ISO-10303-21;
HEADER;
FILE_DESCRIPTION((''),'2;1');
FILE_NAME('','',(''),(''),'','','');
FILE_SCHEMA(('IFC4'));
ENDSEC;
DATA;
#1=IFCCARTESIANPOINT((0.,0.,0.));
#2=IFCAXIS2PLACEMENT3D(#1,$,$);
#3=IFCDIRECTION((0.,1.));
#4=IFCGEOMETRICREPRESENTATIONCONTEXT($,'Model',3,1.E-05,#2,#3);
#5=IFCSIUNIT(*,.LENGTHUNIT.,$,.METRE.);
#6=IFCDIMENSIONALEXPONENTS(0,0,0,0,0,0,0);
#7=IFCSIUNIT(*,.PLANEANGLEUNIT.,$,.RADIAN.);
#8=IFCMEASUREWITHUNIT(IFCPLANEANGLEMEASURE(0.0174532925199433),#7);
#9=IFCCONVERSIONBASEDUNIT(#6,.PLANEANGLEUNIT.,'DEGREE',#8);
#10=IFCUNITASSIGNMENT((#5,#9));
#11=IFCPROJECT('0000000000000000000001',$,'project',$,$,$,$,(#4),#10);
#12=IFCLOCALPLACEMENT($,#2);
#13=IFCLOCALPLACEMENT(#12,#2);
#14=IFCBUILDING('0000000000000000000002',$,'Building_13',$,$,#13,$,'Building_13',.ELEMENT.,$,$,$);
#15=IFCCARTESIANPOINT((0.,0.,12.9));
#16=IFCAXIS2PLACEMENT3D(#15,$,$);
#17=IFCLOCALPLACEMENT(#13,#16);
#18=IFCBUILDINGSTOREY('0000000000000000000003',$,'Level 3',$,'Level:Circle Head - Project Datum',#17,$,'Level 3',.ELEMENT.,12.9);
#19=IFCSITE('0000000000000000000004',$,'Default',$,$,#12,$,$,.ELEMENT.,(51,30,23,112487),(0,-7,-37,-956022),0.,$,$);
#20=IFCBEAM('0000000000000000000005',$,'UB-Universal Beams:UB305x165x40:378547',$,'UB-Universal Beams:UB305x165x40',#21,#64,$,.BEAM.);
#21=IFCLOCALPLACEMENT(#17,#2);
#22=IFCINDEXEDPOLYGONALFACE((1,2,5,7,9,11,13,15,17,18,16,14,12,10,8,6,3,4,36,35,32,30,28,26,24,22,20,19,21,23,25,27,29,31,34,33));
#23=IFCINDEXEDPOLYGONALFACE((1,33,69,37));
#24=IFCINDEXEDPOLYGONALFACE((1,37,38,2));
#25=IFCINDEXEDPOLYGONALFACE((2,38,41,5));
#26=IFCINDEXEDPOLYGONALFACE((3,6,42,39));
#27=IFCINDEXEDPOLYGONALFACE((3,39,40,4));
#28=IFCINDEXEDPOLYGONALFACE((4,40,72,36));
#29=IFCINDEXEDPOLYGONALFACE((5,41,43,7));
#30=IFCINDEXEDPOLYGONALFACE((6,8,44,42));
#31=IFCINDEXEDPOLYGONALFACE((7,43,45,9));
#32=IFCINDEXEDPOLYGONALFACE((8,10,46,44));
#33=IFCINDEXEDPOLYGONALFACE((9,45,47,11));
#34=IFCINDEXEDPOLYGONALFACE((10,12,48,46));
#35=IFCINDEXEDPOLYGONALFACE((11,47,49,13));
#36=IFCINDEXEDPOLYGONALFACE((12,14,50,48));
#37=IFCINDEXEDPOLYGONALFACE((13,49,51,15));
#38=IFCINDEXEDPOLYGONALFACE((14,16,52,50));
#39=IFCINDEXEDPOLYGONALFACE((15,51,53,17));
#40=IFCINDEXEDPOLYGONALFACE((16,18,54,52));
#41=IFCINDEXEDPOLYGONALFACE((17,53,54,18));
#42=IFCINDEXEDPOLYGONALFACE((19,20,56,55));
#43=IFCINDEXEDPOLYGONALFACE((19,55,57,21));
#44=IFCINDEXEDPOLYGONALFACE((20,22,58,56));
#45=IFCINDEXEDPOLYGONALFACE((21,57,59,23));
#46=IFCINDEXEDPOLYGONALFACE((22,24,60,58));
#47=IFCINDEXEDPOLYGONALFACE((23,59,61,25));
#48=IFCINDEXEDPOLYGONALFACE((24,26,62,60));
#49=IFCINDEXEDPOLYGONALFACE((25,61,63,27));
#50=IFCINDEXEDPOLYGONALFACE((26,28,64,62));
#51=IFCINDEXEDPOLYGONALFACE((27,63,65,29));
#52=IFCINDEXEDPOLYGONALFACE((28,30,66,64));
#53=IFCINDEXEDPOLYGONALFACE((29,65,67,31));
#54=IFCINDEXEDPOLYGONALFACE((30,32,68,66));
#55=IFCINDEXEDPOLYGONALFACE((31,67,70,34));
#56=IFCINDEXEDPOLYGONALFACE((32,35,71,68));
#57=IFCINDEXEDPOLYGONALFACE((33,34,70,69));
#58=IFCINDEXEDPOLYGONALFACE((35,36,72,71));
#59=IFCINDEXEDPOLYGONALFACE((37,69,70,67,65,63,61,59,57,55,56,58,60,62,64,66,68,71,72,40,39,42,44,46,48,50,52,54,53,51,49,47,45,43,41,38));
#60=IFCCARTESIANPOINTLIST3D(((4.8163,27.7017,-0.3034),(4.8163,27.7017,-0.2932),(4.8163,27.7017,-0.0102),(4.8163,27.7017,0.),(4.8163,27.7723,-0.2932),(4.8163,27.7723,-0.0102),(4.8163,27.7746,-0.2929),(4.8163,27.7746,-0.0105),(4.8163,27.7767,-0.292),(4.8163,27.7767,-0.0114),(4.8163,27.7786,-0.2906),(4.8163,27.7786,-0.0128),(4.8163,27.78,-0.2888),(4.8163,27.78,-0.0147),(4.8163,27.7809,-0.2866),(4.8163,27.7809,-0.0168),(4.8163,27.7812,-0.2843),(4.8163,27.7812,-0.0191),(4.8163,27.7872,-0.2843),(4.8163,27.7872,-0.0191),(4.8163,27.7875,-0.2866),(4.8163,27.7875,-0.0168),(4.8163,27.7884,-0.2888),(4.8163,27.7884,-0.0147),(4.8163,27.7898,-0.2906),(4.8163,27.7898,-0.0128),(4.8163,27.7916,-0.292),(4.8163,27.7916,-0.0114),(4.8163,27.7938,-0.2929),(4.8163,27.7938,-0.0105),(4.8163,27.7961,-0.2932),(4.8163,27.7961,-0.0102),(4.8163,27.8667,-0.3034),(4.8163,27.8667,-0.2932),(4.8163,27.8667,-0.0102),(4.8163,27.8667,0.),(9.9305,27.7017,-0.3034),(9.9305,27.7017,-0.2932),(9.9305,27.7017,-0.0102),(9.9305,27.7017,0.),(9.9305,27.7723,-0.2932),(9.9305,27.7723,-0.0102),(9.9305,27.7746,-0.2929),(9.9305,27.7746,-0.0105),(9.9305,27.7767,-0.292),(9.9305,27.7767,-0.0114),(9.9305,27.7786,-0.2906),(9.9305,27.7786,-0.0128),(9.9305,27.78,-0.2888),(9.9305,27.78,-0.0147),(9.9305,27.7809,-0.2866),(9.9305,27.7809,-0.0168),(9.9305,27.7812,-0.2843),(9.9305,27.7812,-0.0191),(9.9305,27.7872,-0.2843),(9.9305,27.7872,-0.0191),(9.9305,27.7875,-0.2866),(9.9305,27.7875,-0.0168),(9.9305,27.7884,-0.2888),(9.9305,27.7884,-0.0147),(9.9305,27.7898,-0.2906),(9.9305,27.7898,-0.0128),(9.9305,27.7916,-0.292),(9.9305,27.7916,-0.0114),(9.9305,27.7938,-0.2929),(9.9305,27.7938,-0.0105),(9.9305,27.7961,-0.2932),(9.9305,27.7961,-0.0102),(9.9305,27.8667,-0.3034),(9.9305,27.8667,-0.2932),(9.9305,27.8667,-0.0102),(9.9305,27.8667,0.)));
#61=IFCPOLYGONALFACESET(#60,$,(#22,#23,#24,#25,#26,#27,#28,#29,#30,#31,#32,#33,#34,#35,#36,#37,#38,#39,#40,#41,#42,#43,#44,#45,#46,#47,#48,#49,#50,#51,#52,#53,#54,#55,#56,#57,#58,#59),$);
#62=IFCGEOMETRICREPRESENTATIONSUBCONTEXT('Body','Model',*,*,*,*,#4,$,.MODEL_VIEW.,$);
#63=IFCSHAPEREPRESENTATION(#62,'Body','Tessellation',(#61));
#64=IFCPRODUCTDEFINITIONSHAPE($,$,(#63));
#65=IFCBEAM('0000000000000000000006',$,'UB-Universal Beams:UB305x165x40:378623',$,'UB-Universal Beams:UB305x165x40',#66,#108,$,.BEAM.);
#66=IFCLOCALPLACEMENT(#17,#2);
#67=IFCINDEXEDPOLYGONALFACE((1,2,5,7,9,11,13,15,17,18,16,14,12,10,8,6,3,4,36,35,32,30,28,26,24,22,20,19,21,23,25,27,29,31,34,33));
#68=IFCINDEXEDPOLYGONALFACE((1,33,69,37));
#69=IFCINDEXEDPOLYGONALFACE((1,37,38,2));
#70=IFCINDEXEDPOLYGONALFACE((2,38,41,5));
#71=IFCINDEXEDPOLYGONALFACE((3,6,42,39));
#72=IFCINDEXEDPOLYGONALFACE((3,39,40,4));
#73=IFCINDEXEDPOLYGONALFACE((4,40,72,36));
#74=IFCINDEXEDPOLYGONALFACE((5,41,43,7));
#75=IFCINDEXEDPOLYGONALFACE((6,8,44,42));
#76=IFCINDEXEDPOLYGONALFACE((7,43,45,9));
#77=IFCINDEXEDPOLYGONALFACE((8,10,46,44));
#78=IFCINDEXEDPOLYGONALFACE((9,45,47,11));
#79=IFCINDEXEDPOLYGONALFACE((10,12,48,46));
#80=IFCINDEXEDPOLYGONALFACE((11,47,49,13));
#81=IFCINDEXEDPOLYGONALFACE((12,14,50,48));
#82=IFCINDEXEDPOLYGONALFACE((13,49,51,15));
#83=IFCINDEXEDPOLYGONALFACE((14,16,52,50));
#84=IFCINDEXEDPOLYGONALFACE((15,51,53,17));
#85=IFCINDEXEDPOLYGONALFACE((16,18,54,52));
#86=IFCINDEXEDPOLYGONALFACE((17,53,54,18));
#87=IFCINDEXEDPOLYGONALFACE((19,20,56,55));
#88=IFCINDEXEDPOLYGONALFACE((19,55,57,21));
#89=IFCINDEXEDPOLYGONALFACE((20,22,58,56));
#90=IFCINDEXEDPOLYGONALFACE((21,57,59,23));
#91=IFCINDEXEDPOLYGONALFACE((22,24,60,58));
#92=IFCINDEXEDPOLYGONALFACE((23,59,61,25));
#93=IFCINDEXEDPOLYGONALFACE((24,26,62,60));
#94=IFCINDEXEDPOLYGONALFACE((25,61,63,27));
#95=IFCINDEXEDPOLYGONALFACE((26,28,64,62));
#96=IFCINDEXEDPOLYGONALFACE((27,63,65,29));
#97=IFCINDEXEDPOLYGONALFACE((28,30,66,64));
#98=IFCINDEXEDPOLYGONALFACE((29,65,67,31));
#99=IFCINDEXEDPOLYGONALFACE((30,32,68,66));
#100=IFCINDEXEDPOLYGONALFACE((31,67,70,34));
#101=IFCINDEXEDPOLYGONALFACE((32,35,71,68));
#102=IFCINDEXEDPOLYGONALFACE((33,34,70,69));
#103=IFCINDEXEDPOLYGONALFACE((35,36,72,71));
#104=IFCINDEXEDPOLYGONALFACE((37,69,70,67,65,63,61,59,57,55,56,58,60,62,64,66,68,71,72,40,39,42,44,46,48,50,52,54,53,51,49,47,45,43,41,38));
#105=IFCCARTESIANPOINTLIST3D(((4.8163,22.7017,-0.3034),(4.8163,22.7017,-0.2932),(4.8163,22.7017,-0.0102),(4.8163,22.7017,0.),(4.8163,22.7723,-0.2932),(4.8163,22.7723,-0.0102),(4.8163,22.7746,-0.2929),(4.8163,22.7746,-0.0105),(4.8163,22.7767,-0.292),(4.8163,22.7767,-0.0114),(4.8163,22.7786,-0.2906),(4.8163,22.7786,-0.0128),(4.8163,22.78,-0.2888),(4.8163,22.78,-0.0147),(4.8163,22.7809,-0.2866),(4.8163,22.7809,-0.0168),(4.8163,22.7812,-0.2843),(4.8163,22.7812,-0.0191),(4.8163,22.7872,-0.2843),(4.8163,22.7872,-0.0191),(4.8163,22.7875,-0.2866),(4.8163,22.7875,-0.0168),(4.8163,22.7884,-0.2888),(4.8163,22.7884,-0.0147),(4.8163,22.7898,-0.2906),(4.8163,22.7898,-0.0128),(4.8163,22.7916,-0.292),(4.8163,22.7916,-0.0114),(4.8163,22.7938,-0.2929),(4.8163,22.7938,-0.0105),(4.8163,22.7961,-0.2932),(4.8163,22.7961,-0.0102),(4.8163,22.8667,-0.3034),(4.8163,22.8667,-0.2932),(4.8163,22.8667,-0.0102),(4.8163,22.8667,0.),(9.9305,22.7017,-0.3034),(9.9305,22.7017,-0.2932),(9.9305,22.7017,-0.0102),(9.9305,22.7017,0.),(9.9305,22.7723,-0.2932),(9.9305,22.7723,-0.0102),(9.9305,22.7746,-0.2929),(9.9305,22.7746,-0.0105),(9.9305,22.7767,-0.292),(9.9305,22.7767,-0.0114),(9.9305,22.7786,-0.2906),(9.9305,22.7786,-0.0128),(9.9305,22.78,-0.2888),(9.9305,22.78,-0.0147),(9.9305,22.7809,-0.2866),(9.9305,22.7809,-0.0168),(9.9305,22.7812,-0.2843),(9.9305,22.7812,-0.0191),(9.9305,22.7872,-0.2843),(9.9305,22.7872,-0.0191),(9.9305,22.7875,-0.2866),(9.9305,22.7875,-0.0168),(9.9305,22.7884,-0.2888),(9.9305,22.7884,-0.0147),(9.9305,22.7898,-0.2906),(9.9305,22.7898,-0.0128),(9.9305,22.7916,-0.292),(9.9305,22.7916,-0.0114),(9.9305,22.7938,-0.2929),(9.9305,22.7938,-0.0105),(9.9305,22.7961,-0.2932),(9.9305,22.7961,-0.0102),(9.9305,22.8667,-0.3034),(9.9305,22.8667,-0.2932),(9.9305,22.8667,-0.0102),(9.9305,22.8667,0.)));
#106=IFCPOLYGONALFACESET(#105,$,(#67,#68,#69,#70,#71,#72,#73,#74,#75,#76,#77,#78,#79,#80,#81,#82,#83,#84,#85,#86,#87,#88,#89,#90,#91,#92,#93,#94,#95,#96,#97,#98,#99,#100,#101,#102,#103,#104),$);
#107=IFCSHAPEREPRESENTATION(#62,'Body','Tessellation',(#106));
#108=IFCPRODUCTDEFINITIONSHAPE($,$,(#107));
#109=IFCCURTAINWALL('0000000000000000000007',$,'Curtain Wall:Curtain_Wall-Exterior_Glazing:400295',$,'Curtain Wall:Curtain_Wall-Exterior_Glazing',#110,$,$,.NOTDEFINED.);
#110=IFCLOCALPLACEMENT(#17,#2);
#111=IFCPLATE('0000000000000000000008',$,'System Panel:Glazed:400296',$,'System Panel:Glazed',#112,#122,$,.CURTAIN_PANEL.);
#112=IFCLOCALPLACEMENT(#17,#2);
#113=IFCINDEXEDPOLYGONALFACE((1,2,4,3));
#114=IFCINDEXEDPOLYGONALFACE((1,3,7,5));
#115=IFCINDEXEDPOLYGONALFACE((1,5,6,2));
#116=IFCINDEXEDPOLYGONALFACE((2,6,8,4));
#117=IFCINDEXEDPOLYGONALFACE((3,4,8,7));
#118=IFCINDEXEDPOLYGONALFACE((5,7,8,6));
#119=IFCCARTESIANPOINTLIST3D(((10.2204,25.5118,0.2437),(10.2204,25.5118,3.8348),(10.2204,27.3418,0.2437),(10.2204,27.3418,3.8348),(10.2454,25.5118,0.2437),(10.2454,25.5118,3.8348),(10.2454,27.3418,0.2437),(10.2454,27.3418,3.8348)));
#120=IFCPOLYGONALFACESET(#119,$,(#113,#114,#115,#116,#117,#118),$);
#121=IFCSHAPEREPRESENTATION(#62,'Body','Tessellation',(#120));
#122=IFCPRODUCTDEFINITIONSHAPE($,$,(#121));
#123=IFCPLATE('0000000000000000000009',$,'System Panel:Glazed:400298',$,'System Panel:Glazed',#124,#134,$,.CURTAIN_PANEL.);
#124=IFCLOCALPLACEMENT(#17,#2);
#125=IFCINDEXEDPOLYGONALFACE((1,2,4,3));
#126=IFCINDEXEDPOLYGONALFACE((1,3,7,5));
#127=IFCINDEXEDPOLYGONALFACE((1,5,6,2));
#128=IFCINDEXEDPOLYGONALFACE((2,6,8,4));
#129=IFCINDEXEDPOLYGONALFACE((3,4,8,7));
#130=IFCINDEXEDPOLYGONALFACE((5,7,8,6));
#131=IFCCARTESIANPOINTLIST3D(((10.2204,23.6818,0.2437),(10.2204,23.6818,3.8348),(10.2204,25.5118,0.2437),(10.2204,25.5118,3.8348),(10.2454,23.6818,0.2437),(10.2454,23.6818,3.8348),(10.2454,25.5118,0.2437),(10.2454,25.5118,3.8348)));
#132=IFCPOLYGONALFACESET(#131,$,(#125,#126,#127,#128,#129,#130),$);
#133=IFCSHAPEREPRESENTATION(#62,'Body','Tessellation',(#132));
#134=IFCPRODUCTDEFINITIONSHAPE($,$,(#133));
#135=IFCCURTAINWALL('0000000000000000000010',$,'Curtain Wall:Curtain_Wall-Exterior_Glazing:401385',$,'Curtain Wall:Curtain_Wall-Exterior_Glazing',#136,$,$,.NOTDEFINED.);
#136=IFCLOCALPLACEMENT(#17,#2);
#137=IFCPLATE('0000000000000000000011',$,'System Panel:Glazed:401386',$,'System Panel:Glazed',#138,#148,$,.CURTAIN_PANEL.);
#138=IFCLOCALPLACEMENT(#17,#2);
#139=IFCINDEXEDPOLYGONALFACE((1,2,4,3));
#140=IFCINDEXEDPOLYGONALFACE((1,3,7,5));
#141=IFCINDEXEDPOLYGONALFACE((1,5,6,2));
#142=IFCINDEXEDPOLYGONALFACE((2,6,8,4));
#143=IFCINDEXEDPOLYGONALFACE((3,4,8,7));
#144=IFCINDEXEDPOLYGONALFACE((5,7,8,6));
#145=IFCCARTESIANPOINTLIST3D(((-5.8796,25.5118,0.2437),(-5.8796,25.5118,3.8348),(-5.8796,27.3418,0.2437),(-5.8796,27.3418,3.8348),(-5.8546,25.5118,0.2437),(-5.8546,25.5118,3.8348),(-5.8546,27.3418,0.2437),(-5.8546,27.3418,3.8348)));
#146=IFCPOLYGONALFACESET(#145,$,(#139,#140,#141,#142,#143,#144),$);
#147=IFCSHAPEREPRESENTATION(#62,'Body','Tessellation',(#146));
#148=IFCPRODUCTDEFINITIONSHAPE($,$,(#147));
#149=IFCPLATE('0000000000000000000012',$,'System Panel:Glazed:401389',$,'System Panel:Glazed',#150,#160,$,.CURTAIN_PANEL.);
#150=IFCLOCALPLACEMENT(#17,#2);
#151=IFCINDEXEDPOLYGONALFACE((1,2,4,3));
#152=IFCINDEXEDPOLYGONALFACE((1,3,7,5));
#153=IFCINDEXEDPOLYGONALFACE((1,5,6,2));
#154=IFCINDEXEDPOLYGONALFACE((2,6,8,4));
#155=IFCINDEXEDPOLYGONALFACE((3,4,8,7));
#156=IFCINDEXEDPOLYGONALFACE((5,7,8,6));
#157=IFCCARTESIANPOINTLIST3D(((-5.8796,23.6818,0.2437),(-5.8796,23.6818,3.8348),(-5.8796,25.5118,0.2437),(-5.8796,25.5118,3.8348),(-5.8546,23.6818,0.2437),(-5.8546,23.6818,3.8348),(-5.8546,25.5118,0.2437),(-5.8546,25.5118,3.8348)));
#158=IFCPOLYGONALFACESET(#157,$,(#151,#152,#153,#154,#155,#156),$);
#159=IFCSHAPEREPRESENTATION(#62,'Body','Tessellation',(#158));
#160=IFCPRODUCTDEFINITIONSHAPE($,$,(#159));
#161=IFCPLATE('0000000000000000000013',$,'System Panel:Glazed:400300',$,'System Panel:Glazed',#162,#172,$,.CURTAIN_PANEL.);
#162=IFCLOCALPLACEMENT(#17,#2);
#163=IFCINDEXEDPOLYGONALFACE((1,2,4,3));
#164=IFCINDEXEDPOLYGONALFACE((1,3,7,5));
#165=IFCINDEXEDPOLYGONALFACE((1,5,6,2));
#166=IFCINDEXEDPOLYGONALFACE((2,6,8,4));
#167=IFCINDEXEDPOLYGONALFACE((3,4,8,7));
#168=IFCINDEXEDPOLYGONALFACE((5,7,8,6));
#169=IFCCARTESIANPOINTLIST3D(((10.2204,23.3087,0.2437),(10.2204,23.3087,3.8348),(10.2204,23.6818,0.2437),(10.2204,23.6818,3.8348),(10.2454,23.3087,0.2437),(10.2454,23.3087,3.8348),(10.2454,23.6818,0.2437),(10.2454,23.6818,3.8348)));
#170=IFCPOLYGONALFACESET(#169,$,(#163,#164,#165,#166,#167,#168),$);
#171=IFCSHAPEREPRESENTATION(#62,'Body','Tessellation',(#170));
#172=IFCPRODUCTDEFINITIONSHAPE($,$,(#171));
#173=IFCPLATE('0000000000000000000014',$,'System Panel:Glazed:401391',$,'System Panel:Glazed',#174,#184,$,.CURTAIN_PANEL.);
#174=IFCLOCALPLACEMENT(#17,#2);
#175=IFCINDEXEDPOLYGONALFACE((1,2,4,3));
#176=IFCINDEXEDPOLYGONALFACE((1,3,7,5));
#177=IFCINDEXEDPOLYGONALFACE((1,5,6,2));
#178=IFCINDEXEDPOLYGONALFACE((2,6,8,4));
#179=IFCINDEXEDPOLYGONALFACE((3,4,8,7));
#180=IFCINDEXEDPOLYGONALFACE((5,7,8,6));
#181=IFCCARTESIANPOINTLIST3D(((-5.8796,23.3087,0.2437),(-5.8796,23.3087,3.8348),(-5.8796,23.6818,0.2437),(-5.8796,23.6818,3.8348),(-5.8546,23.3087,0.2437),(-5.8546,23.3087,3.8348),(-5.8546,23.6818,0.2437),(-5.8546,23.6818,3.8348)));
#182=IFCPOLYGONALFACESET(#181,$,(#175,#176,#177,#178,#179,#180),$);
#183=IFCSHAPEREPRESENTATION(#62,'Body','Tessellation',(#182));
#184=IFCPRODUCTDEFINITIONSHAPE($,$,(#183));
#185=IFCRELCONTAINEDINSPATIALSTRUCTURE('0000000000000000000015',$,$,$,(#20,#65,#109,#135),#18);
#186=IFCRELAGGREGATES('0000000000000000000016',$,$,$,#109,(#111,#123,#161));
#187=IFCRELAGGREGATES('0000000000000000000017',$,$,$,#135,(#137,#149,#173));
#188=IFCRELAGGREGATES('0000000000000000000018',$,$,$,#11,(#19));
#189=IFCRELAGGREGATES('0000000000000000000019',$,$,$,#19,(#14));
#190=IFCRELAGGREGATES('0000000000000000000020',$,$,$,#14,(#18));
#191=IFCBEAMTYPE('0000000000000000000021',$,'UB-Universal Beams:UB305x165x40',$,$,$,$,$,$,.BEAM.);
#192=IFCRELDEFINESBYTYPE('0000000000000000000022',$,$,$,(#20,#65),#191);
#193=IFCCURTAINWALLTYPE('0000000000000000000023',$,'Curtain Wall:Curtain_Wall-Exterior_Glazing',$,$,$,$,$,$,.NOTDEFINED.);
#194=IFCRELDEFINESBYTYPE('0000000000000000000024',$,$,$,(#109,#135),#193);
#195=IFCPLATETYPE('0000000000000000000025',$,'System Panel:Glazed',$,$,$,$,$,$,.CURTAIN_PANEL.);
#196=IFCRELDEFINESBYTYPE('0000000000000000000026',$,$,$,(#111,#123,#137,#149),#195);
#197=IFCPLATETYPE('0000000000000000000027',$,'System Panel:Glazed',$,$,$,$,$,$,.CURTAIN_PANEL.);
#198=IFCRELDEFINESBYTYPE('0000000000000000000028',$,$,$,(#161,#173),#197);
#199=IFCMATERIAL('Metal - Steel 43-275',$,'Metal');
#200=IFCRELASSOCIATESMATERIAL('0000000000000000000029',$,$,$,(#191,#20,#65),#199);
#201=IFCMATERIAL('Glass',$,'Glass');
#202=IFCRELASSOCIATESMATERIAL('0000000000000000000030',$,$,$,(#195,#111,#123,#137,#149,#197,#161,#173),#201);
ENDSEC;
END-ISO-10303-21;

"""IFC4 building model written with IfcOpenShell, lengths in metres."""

from ifc_helpers import new_model, entity, si_unit, converted_unit, direction, frame, origin, place, context, subcontext, project, spatial, line, arc, indexed_curve, outline, extrude, source, transform, mapped, material, type_object, type_shapes, element, aggregate, save


model = new_model("IFC4")

# Units and contexts
model_context = context("Model", 3, precision=1e-05, world=origin(), true_north=direction((0.0, 1.0)))
body_context = subcontext(model_context, "Body", "Model", "MODEL_VIEW")
ifc_project = project(units=[si_unit("LENGTHUNIT", "METRE"), converted_unit("PLANEANGLEUNIT", "DEGREE", entity("IfcPlaneAngleMeasure", 0.0174532925199433), si_unit("PLANEANGLEUNIT", "RADIAN"), dimensions=[0, 0, 0, 0, 0, 0, 0])], contexts=[model_context])

# Site, building, storey
site_placement = place(None, origin())
site = spatial("IfcSite", under=ifc_project, at=site_placement, Name="Default", CompositionType="ELEMENT", RefLatitude=(51, 30, 23, 112487), RefLongitude=(0, -7, -37, -956022), RefElevation=0.0)
building_placement = place(site_placement, origin())
building = spatial("IfcBuilding", under=site, at=building_placement, Name="Building_13", LongName="Building_13", CompositionType="ELEMENT")
storey_placement = place(building_placement, frame((0.0, 0.0, 12.9)))
storey = spatial("IfcBuildingStorey", under=building, at=storey_placement, Name="Level 3", ObjectType="Level:Circle Head - Project Datum", LongName="Level 3", CompositionType="ELEMENT", Elevation=12.9)

# Beams
ifc_material_1 = material(Name="Metal - Steel 43-275", Category="Metal")
beam_type_1 = type_object("IfcBeamType", Name="UB-Universal Beams:UB305x165x40", PredefinedType="BEAM", material=ifc_material_1)
shared_shape_1 = source(origin(), body_context, "Body", "SweptSolid", [
    extrude(outline(indexed_curve([(-0.0825, -0.1415), (-0.0825, -0.1517), (0.0825, -0.1517), (0.0825, -0.1415), (0.0119, -0.1415), (0.0056, -0.1389), (0.003, -0.1326), (0.003, 0.1326), (0.0056, 0.1389), (0.0119, 0.1415), (0.0825, 0.1415), (0.0825, 0.1517), (-0.0825, 0.1517), (-0.0825, 0.1415), (-0.0119, 0.1415), (-0.0056, 0.1389), (-0.003, 0.1326), (-0.003, -0.1326), (-0.0056, -0.1389), (-0.0119, -0.1415)], segments=[line(1, 2, 3, 4, 5), arc(5, 6, 7), line(7, 8), arc(8, 9, 10), line(10, 11, 12, 13, 14, 15), arc(15, 16, 17), line(17, 18), arc(18, 19, 20), line(20, 1)], self_intersect=False)), frame((-2.5571, 0.0, 0.0), z_axis=(-1.0, 0.0, 0.0), x_axis=(0.0, -1.0, 0.0)), (0.0, 0.0, -1.0), 5.1142),
])
type_shapes(beam_type_1, [shared_shape_1])
for number, where, name in (
    (1, (7.3734, 27.7842, -0.1517), "UB-Universal Beams:UB305x165x40:378547"),
    (2, (7.3734, 22.7842, -0.1517), "UB-Universal Beams:UB305x165x40:378623"),
):
    element("IfcBeam", number, at=place(storey_placement, frame(where)), inside=storey, type_object=beam_type_1, material=ifc_material_1, Name=name, ObjectType="UB-Universal Beams:UB305x165x40", PredefinedType="BEAM", context=body_context, shape_type="MappedRepresentation", body=[
        mapped(shared_shape_1, transform((0.0, 0.0, 0.0), scale=1.0)),
    ])

# Curtain walls, plates
curtain_wall_type = type_object("IfcCurtainWallType", Name="Curtain Wall:Curtain_Wall-Exterior_Glazing", PredefinedType="NOTDEFINED")
curtain_wall_1_placement = place(storey_placement, frame((0.0, 0.0, -12.9)))
curtain_wall_1 = element("IfcCurtainWall", 3, at=curtain_wall_1_placement, inside=storey, type_object=curtain_wall_type, Name="Curtain Wall:Curtain_Wall-Exterior_Glazing:400295", ObjectType="Curtain Wall:Curtain_Wall-Exterior_Glazing", PredefinedType="NOTDEFINED")
ifc_material_2 = material(Name="Glass", Category="Glass")
plate_type_1 = type_object("IfcPlateType", Name="System Panel:Glazed", PredefinedType="CURTAIN_PANEL", material=ifc_material_2)
shared_shape_2 = source(origin(), body_context, "Body", "SweptSolid", [
    extrude(outline(indexed_curve([(-0.0125, -0.915), (0.0125, -0.915), (0.0125, 0.915), (-0.0125, 0.915), (-0.0125, -0.915)], self_intersect=False)), frame((0.0, 0.037, 0.0), z_axis=(0.0, 0.0, 1.0), x_axis=(0.0, 1.0, 0.0)), (0.0, 0.0, 1.0), 3.5911),
])
type_shapes(plate_type_1, [shared_shape_2])
plate_1_placement = place(curtain_wall_1_placement, frame((10.1959, 26.4268, 13.1437), z_axis=(0.0, 0.0, 1.0), x_axis=(0.0, -1.0, 0.0)))
plate_1 = element("IfcPlate", 4, at=plate_1_placement, type_object=plate_type_1, material=ifc_material_2, Name="System Panel:Glazed:400296", ObjectType="System Panel:Glazed", PredefinedType="CURTAIN_PANEL", context=body_context, shape_type="MappedRepresentation", body=[
    mapped(shared_shape_2, transform((0.0, 0.0, 0.0), scale=1.0)),
])
plate_2_placement = place(curtain_wall_1_placement, frame((10.1959, 24.5968, 13.1437), z_axis=(0.0, 0.0, 1.0), x_axis=(0.0, -1.0, 0.0)))
plate_2 = element("IfcPlate", 5, at=plate_2_placement, type_object=plate_type_1, material=ifc_material_2, Name="System Panel:Glazed:400298", ObjectType="System Panel:Glazed", PredefinedType="CURTAIN_PANEL", context=body_context, shape_type="MappedRepresentation", body=[
    mapped(shared_shape_2, transform((0.0, 0.0, 0.0), scale=1.0)),
])
curtain_wall_2_placement = place(storey_placement, frame((0.0, 0.0, -12.9)))
curtain_wall_2 = element("IfcCurtainWall", 6, at=curtain_wall_2_placement, inside=storey, type_object=curtain_wall_type, Name="Curtain Wall:Curtain_Wall-Exterior_Glazing:401385", ObjectType="Curtain Wall:Curtain_Wall-Exterior_Glazing", PredefinedType="NOTDEFINED")
plate_3_placement = place(curtain_wall_2_placement, frame((-5.9041, 26.4268, 13.1437), z_axis=(0.0, 0.0, 1.0), x_axis=(0.0, -1.0, 0.0)))
plate_3 = element("IfcPlate", 7, at=plate_3_placement, type_object=plate_type_1, material=ifc_material_2, Name="System Panel:Glazed:401386", ObjectType="System Panel:Glazed", PredefinedType="CURTAIN_PANEL", context=body_context, shape_type="MappedRepresentation", body=[
    mapped(shared_shape_2, transform((0.0, 0.0, 0.0), scale=1.0)),
])
plate_4_placement = place(curtain_wall_2_placement, frame((-5.9041, 24.5968, 13.1437), z_axis=(0.0, 0.0, 1.0), x_axis=(0.0, -1.0, 0.0)))
plate_4 = element("IfcPlate", 8, at=plate_4_placement, type_object=plate_type_1, material=ifc_material_2, Name="System Panel:Glazed:401389", ObjectType="System Panel:Glazed", PredefinedType="CURTAIN_PANEL", context=body_context, shape_type="MappedRepresentation", body=[
    mapped(shared_shape_2, transform((0.0, 0.0, 0.0), scale=1.0)),
])

# Plates
plate_type_2 = type_object("IfcPlateType", Name="System Panel:Glazed", PredefinedType="CURTAIN_PANEL", material=ifc_material_2)
shared_shape_3 = source(origin(), body_context, "Body", "SweptSolid", [
    extrude(outline(indexed_curve([(-0.0125, -0.1866), (0.0125, -0.1866), (0.0125, 0.1866), (-0.0125, 0.1866), (-0.0125, -0.1866)], self_intersect=False)), frame((0.0, 0.037, 0.0), z_axis=(0.0, 0.0, 1.0), x_axis=(0.0, 1.0, 0.0)), (0.0, 0.0, 1.0), 3.5911),
])
type_shapes(plate_type_2, [shared_shape_3])
plate_5_placement = place(curtain_wall_1_placement, frame((10.1959, 23.4953, 13.1437), z_axis=(0.0, 0.0, 1.0), x_axis=(0.0, -1.0, 0.0)))
plate_5 = element("IfcPlate", 9, at=plate_5_placement, type_object=plate_type_2, material=ifc_material_2, Name="System Panel:Glazed:400300", ObjectType="System Panel:Glazed", PredefinedType="CURTAIN_PANEL", context=body_context, shape_type="MappedRepresentation", body=[
    mapped(shared_shape_3, transform((0.0, 0.0, 0.0), scale=1.0)),
])
aggregate(curtain_wall_1, [plate_1, plate_2, plate_5])
plate_6_placement = place(curtain_wall_2_placement, frame((-5.9041, 23.4953, 13.1437), z_axis=(0.0, 0.0, 1.0), x_axis=(0.0, -1.0, 0.0)))
plate_6 = element("IfcPlate", 10, at=plate_6_placement, type_object=plate_type_2, material=ifc_material_2, Name="System Panel:Glazed:401391", ObjectType="System Panel:Glazed", PredefinedType="CURTAIN_PANEL", context=body_context, shape_type="MappedRepresentation", body=[
    mapped(shared_shape_3, transform((0.0, 0.0, 0.0), scale=1.0)),
])
aggregate(curtain_wall_2, [plate_3, plate_4, plate_6])

save(model, "model.ifc")
